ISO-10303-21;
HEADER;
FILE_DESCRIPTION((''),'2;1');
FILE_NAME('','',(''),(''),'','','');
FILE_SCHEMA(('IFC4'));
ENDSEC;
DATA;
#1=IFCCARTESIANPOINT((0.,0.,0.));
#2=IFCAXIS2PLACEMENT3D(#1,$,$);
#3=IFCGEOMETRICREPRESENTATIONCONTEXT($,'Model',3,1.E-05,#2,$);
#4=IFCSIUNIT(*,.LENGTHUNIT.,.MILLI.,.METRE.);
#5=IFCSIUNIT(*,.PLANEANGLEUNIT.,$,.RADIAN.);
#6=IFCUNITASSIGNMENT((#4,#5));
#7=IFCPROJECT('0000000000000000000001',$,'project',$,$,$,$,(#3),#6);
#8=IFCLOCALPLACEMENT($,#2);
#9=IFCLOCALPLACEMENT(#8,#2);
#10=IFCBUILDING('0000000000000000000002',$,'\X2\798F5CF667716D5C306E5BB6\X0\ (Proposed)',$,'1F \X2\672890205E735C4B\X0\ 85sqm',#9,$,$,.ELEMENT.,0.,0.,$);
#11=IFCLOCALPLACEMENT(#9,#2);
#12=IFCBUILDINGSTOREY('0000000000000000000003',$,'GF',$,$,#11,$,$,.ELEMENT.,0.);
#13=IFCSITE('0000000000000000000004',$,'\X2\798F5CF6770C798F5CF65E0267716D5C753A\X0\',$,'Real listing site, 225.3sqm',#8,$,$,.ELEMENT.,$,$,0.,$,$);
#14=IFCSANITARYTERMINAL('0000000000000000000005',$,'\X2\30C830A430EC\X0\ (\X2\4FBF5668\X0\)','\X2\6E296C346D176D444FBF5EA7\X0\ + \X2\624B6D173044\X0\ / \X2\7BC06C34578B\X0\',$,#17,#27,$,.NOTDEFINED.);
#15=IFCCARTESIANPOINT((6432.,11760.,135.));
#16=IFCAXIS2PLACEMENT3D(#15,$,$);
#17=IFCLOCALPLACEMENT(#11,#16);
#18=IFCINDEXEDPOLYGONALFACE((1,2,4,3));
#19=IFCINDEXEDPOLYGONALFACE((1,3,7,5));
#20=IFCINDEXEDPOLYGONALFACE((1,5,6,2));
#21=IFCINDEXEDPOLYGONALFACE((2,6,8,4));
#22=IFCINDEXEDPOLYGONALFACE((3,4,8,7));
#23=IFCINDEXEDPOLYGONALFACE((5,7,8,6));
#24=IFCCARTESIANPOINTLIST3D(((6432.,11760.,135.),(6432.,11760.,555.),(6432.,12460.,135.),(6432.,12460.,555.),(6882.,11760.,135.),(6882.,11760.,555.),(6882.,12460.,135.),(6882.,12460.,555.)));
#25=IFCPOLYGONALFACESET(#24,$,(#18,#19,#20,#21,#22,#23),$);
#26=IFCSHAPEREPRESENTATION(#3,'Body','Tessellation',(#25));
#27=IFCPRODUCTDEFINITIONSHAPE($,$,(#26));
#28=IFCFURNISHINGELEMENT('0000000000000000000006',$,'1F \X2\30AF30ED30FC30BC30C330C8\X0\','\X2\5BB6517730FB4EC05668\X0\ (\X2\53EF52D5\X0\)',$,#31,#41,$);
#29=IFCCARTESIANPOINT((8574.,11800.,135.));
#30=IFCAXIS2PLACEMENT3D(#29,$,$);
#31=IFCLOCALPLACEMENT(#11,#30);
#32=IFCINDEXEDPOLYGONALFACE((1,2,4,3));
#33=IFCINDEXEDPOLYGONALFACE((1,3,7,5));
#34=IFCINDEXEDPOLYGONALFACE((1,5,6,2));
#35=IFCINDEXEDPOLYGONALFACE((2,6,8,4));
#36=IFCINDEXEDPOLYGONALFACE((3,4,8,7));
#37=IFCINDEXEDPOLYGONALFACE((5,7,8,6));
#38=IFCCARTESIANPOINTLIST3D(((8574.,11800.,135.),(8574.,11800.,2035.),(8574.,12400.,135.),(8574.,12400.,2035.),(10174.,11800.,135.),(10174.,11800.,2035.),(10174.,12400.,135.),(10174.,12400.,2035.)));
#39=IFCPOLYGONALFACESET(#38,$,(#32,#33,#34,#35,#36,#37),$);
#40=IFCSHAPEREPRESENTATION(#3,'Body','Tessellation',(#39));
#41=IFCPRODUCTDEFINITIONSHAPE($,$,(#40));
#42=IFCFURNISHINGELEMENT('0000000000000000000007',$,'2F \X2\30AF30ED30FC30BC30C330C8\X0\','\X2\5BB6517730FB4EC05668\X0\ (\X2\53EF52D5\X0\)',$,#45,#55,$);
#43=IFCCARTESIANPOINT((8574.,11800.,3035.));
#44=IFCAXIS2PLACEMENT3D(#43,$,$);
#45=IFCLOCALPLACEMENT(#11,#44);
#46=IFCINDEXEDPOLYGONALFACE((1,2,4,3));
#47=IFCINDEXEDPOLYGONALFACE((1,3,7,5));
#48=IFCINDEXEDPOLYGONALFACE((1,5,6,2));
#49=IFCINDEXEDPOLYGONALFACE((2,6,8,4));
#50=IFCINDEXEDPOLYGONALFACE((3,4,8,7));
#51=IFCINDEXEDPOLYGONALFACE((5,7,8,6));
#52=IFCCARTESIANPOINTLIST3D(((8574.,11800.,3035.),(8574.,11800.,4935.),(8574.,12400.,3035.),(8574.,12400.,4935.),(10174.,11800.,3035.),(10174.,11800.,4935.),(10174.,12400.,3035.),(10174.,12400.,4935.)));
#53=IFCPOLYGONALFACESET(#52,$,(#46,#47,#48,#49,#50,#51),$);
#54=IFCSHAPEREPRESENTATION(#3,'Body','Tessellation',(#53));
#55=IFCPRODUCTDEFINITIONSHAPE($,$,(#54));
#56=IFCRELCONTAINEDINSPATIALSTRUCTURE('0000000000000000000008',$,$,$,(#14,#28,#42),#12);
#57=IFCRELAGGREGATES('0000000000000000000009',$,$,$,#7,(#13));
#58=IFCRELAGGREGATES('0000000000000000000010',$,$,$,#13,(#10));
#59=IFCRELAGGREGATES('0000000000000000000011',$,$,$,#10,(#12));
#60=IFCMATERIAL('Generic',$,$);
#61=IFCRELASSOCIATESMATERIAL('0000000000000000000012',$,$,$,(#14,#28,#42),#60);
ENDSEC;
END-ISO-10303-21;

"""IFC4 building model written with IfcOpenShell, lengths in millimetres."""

from ifc_helpers import new_model, si_unit, frame, frame_2d, origin, place, context, project, spatial, rectangle, extrude, material, element, save


model = new_model("IFC4")

# Units and contexts
model_context = context("Model", 3, precision=1e-05, world=origin())
ifc_project = project(units=[si_unit("LENGTHUNIT", "METRE", prefix="MILLI"), si_unit("PLANEANGLEUNIT", "RADIAN")], contexts=[model_context])

# Site, building, storey
site_placement = place(None, origin())
site = spatial("IfcSite", under=ifc_project, at=site_placement, Name="福島県福島市東浜町", ObjectType="Real listing site, 225.3sqm", CompositionType="ELEMENT", RefElevation=0.0)
building_placement = place(site_placement, origin())
building = spatial("IfcBuilding", under=site, at=building_placement, Name="福島東浜の家 (Proposed)", ObjectType="1F 木造平屋 85sqm", CompositionType="ELEMENT", ElevationOfRefHeight=0.0, ElevationOfTerrain=0.0)
storey_placement = place(building_placement, origin())
storey = spatial("IfcBuildingStorey", under=building, at=storey_placement, Name="GF", CompositionType="ELEMENT", Elevation=0.0)

# Sanitary terminal
ifc_material_1 = material(Name="Generic")
sanitary_terminal_1_placement = place(storey_placement, frame((6432.0, 11760.0, 135.0)))
element("IfcSanitaryTerminal", 1, at=sanitary_terminal_1_placement, inside=storey, material=ifc_material_1, Name="トイレ (便器)", Description="温水洗浄便座 + 手洗い / 節水型", PredefinedType="NOTDEFINED", context=model_context, shape_type="SweptSolid", body=[
    extrude(rectangle(XDim=450.0, YDim=700.0, at=frame_2d((225.0, 350.0))), frame((6432.0, 11760.0, 135.0)), (0.0, 0.0, 1.0), 420.0),
])

# Furnishing elements
furnishing_1_placement = place(storey_placement, frame((8574.0, 11800.0, 135.0)))
element("IfcFurnishingElement", 2, at=furnishing_1_placement, inside=storey, material=ifc_material_1, Name="1F クローゼット", Description="家具・什器 (可動)", context=model_context, shape_type="SweptSolid", body=[
    extrude(rectangle(XDim=1600.0, YDim=600.0, at=frame_2d((800.0, 300.0))), frame((8574.0, 11800.0, 135.0)), (0.0, 0.0, 1.0), 1900.0),
])
furnishing_2_placement = place(storey_placement, frame((8574.0, 11800.0, 3035.0)))
element("IfcFurnishingElement", 3, at=furnishing_2_placement, inside=storey, material=ifc_material_1, Name="2F クローゼット", Description="家具・什器 (可動)", context=model_context, shape_type="SweptSolid", body=[
    extrude(rectangle(XDim=1600.0, YDim=600.0, at=frame_2d((800.0, 300.0))), frame((8574.0, 11800.0, 3035.0)), (0.0, 0.0, 1.0), 1900.0),
])

save(model, "model.ifc")
